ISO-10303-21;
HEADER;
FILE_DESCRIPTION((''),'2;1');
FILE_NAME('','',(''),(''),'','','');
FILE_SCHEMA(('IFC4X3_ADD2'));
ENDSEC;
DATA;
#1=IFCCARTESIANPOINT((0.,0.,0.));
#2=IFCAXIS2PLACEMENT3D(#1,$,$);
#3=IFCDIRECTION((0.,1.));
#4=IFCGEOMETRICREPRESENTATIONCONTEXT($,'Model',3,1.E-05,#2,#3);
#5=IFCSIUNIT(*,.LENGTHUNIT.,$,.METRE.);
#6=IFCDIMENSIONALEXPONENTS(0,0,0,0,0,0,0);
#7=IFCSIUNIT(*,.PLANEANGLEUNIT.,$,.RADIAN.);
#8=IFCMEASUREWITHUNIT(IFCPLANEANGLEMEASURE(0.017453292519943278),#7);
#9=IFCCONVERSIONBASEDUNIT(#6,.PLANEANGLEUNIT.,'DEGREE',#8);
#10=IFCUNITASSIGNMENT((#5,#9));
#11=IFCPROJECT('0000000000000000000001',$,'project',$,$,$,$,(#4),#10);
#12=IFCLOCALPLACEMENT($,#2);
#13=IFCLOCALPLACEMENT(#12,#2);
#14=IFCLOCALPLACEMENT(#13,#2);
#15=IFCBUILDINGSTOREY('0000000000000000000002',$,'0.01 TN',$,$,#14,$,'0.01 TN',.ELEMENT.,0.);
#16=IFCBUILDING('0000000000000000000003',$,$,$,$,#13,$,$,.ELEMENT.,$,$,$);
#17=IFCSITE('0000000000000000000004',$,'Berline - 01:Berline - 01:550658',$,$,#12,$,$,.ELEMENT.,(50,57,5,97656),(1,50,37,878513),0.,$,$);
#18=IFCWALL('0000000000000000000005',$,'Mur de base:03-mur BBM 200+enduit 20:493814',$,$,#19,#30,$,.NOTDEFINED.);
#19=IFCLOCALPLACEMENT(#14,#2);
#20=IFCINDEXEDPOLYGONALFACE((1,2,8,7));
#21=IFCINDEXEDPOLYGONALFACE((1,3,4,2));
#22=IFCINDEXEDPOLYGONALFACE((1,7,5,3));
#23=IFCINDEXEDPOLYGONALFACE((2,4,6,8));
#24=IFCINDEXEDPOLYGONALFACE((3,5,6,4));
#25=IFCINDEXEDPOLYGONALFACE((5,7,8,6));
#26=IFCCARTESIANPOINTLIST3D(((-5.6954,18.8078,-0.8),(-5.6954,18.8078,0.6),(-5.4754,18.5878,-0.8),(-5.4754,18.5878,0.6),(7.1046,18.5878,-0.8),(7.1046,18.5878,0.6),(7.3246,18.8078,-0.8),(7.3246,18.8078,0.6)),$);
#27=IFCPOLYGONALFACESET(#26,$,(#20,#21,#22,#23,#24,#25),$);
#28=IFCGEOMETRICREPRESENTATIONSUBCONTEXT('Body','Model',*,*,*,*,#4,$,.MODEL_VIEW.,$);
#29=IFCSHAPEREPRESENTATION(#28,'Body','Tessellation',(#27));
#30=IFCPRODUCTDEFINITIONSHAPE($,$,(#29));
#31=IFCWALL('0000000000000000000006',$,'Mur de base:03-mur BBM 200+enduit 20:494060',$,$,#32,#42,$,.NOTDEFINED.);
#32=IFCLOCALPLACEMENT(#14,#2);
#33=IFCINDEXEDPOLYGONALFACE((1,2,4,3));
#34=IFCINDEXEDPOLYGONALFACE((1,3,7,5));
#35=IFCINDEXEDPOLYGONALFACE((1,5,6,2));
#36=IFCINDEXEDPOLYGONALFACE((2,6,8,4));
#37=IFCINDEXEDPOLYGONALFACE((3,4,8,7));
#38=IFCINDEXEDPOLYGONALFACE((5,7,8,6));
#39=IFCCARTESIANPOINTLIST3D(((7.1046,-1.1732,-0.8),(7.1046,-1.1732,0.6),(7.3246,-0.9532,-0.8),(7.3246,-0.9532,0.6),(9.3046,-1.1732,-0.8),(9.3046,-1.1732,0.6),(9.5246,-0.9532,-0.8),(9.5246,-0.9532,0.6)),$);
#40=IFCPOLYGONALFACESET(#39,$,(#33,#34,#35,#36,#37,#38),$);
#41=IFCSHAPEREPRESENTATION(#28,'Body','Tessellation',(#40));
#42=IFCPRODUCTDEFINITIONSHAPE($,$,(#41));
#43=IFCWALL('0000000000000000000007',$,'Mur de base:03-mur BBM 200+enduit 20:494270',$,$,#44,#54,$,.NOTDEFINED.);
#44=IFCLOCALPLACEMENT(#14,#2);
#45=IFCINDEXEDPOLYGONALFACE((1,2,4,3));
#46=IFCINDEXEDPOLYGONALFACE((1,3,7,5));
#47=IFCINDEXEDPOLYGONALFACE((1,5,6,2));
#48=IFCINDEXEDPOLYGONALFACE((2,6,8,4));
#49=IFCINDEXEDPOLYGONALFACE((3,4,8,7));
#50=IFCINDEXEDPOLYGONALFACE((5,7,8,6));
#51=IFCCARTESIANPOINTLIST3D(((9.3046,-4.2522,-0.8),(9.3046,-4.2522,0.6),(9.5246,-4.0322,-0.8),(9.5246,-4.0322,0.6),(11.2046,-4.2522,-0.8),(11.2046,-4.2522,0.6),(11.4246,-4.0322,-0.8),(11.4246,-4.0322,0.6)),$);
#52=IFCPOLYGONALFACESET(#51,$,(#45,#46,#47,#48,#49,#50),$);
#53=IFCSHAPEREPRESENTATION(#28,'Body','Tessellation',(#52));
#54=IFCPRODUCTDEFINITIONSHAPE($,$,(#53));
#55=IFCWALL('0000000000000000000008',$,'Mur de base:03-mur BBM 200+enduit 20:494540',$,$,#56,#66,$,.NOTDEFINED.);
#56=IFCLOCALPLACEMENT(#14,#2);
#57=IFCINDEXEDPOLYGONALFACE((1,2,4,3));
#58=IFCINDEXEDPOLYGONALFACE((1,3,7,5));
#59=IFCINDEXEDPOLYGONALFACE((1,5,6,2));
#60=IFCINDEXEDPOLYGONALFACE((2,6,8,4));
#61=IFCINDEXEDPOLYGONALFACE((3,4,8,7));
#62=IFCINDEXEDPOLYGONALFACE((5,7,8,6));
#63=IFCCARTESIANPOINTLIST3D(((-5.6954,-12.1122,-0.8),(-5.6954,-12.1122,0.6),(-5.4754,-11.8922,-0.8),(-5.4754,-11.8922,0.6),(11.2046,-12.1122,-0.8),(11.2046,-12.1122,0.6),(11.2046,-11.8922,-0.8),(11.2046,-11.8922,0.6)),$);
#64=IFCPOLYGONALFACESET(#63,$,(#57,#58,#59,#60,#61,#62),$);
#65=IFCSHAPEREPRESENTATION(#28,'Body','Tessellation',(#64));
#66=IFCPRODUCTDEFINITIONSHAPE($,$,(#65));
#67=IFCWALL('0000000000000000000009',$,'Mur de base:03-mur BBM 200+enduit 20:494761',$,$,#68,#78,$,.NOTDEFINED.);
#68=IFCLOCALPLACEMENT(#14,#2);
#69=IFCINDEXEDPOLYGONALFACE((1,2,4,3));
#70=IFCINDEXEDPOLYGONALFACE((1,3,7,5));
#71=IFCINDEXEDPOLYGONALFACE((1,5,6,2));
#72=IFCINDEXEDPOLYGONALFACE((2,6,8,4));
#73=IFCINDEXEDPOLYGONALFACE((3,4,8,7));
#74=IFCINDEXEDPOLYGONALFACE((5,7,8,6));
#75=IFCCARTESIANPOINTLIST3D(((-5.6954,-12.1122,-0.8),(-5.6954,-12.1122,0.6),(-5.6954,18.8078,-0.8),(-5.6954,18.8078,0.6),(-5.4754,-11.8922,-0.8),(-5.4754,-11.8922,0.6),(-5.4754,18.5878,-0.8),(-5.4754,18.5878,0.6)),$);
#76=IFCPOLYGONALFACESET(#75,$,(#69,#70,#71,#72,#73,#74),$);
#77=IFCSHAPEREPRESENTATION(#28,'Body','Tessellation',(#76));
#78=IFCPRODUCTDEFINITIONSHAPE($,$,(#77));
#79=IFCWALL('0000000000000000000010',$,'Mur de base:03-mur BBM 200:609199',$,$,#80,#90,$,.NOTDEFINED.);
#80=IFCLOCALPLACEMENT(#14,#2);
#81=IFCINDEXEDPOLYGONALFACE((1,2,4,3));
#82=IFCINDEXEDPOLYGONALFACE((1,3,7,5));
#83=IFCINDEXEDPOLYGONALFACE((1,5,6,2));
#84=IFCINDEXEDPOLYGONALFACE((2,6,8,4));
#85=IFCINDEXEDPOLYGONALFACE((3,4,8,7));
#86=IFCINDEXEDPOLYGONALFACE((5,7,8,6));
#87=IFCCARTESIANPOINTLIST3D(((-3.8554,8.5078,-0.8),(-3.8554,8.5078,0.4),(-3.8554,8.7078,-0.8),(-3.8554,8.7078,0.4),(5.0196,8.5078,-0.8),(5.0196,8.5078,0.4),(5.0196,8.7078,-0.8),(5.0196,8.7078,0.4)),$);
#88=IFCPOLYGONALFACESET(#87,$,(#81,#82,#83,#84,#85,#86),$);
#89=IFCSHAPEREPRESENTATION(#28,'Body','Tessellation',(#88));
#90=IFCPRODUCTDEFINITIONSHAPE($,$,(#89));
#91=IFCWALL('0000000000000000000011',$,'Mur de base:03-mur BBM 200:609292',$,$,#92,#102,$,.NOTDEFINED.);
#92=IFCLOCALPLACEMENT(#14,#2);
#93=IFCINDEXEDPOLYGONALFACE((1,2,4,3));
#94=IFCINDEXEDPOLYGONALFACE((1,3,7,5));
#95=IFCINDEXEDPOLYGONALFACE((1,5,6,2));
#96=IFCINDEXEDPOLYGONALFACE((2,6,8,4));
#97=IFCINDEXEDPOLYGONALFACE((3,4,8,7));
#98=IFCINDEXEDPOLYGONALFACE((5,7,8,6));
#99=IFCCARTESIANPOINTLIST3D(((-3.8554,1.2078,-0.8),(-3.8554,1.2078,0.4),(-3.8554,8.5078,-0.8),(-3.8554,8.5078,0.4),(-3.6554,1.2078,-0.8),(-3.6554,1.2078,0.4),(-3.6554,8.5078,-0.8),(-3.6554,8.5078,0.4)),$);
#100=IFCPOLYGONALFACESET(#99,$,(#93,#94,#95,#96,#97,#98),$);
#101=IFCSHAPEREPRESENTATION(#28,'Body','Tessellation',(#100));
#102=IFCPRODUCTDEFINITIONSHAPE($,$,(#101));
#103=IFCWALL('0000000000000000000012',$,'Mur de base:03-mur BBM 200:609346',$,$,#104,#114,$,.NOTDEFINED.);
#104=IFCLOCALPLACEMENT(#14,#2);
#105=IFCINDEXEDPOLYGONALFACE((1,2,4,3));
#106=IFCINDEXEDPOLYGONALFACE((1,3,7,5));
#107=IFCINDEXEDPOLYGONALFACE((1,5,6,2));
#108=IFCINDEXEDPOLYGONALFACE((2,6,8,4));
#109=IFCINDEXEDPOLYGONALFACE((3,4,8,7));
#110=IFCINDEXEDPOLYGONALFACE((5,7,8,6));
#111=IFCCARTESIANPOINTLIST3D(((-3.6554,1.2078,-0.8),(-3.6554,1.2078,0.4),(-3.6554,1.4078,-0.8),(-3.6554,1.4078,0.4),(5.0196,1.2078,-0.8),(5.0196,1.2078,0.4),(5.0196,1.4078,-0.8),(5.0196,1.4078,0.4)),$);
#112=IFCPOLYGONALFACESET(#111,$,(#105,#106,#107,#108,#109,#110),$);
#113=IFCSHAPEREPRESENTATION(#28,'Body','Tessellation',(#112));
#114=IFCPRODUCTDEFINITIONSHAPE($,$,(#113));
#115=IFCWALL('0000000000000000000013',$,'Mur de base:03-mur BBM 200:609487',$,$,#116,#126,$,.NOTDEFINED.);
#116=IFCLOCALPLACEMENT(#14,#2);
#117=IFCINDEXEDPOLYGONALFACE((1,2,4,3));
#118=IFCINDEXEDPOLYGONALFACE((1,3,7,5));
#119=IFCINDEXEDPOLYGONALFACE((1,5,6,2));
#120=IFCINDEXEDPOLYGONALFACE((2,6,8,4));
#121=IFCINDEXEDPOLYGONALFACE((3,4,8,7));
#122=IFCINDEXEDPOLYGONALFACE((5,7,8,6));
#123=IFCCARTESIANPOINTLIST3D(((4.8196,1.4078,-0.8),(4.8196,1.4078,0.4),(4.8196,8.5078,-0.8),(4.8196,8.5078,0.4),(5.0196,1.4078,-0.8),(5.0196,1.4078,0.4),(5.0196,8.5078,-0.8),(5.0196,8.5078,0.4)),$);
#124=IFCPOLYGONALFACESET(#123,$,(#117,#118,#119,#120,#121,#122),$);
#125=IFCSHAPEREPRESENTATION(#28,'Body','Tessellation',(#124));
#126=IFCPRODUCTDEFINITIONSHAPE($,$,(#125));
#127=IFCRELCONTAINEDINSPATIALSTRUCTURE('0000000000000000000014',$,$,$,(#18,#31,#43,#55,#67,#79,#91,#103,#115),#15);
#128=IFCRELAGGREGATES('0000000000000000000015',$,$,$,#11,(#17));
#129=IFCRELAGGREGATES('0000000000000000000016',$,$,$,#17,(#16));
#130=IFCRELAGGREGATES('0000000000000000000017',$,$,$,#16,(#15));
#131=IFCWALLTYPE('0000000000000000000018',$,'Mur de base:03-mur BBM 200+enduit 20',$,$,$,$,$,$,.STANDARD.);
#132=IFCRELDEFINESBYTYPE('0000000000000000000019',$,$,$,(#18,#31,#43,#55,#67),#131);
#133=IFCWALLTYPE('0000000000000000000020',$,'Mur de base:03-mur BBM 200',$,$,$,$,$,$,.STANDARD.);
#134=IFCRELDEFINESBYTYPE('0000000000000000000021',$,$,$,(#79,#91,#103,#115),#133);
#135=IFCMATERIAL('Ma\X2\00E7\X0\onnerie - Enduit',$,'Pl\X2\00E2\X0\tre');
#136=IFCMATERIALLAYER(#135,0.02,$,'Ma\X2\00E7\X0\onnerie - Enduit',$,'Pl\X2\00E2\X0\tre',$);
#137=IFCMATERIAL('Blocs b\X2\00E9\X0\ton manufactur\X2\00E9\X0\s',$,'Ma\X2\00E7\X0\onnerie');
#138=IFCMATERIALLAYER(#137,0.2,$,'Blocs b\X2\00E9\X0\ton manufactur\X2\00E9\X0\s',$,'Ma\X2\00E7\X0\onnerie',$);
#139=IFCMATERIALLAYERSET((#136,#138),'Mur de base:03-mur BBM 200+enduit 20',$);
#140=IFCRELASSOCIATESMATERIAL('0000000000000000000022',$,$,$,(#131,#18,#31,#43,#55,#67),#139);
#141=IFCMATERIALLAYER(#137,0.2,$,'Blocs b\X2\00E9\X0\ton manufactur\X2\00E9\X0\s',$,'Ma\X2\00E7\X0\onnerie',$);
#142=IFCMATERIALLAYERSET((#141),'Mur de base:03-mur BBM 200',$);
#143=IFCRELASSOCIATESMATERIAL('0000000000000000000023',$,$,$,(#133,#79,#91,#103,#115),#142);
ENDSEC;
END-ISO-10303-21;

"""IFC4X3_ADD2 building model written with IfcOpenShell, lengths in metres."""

from ifc_helpers import new_model, entity, si_unit, converted_unit, direction, frame, frame_2d, origin, place, context, subcontext, project, spatial, polyline, rectangle, outline, extrude, material, layer, layer_set, type_object, element, save


model = new_model("IFC4X3_ADD2")

# Units and contexts
model_context = context("Model", 3, precision=1e-05, world=origin(), true_north=direction((0.0, 1.0)))
body_context = subcontext(model_context, "Body", "Model", "MODEL_VIEW")
ifc_project = project(units=[si_unit("LENGTHUNIT", "METRE"), converted_unit("PLANEANGLEUNIT", "DEGREE", entity("IfcPlaneAngleMeasure", 0.017453292519943278), si_unit("PLANEANGLEUNIT", "RADIAN"), dimensions=[0, 0, 0, 0, 0, 0, 0])], contexts=[model_context])

# Site, building, storey
site_placement = place(None, origin())
site = spatial("IfcSite", under=ifc_project, at=site_placement, Name="Berline - 01:Berline - 01:550658", CompositionType="ELEMENT", RefLatitude=(50, 57, 5, 97656), RefLongitude=(1, 50, 37, 878513), RefElevation=0.0)
building_placement = place(site_placement, origin())
building = spatial("IfcBuilding", under=site, at=building_placement, CompositionType="ELEMENT")
storey_placement = place(building_placement, origin())
storey = spatial("IfcBuildingStorey", under=building, at=storey_placement, Name="0.01 TN", LongName="0.01 TN", CompositionType="ELEMENT", Elevation=0.0)

# Walls
ifc_material_1 = material(Name="Maçonnerie - Enduit", Category="Plâtre")
ifc_layer_1 = layer(ifc_material_1, 0.02, Name="Maçonnerie - Enduit", Category="Plâtre")
ifc_material_2 = material(Name="Blocs béton manufacturés", Category="Maçonnerie")
ifc_layer_2 = layer(ifc_material_2, 0.2, Name="Blocs béton manufacturés", Category="Maçonnerie")
ifc_layer_set_1 = layer_set([ifc_layer_1, ifc_layer_2], Name="Mur de base:03-mur BBM 200+enduit 20")
wall_type_1 = type_object("IfcWallType", Name="Mur de base:03-mur BBM 200+enduit 20", PredefinedType="STANDARD", material=ifc_layer_set_1)
wall_1_placement = place(storey_placement, frame((-5.6954, 18.6978, -0.8)))
element("IfcWall", 1, at=wall_1_placement, inside=storey, type_object=wall_type_1, material=ifc_layer_set_1, Name="Mur de base:03-mur BBM 200+enduit 20:493814", PredefinedType="NOTDEFINED", context=body_context, shape_type="SweptSolid", body=[
    extrude(outline(polyline([(12.8, -0.11), (13.02, 0.11), (0.0, 0.11), (0.22, -0.11), (12.8, -0.11)])), origin(), (0.0, 0.0, 1.0), 1.4),
])
wall_2_placement = place(storey_placement, frame((7.1046, -1.0632, -0.8)))
element("IfcWall", 2, at=wall_2_placement, inside=storey, type_object=wall_type_1, material=ifc_layer_set_1, Name="Mur de base:03-mur BBM 200+enduit 20:494060", PredefinedType="NOTDEFINED", context=body_context, shape_type="SweptSolid", body=[
    extrude(outline(polyline([(2.2, -0.11), (2.42, 0.11), (0.22, 0.11), (0.0, -0.11), (2.2, -0.11)])), origin(), (0.0, 0.0, 1.0), 1.4),
])
wall_3_placement = place(storey_placement, frame((9.3046, -4.1422, -0.8)))
element("IfcWall", 3, at=wall_3_placement, inside=storey, type_object=wall_type_1, material=ifc_layer_set_1, Name="Mur de base:03-mur BBM 200+enduit 20:494270", PredefinedType="NOTDEFINED", context=body_context, shape_type="SweptSolid", body=[
    extrude(outline(polyline([(1.9, -0.11), (2.12, 0.11), (0.22, 0.11), (0.0, -0.11), (1.9, -0.11)])), origin(), (0.0, 0.0, 1.0), 1.4),
])
wall_4_placement = place(storey_placement, frame((11.2046, -12.0022, -0.8), z_axis=(0.0, 0.0, 1.0), x_axis=(-1.0, 0.0, 0.0)))
element("IfcWall", 4, at=wall_4_placement, inside=storey, type_object=wall_type_1, material=ifc_layer_set_1, Name="Mur de base:03-mur BBM 200+enduit 20:494540", PredefinedType="NOTDEFINED", context=body_context, shape_type="SweptSolid", body=[
    extrude(outline(polyline([(16.68, -0.11), (16.9, 0.11), (0.0, 0.11), (0.0, -0.11), (16.68, -0.11)])), origin(), (0.0, 0.0, 1.0), 1.4),
])
wall_5_placement = place(storey_placement, frame((-5.5854, -12.1122, -0.8), z_axis=(0.0, 0.0, 1.0), x_axis=(0.0, 1.0, 0.0)))
element("IfcWall", 5, at=wall_5_placement, inside=storey, type_object=wall_type_1, material=ifc_layer_set_1, Name="Mur de base:03-mur BBM 200+enduit 20:494761", PredefinedType="NOTDEFINED", context=body_context, shape_type="SweptSolid", body=[
    extrude(outline(polyline([(30.7, -0.11), (30.92, 0.11), (0.0, 0.11), (0.22, -0.11), (30.7, -0.11)])), origin(), (0.0, 0.0, 1.0), 1.4),
])
ifc_layer_3 = layer(ifc_material_2, 0.2, Name="Blocs béton manufacturés", Category="Maçonnerie")
ifc_layer_set_2 = layer_set([ifc_layer_3], Name="Mur de base:03-mur BBM 200")
wall_type_2 = type_object("IfcWallType", Name="Mur de base:03-mur BBM 200", PredefinedType="STANDARD", material=ifc_layer_set_2)
wall_6_placement = place(storey_placement, frame((5.0196, 8.6078, -0.8), z_axis=(0.0, 0.0, 1.0), x_axis=(-1.0, 0.0, 0.0)))
element("IfcWall", 6, at=wall_6_placement, inside=storey, type_object=wall_type_2, material=ifc_layer_set_2, Name="Mur de base:03-mur BBM 200:609199", PredefinedType="NOTDEFINED", context=body_context, shape_type="SweptSolid", body=[
    extrude(rectangle(XDim=8.875, YDim=0.2, at=frame_2d((4.4375, 0.0), x_axis=(-1.0, 0.0))), origin(), (0.0, 0.0, 1.0), 1.2),
])
wall_7_placement = place(storey_placement, frame((-3.7554, 8.5078, -0.8), z_axis=(0.0, 0.0, 1.0), x_axis=(0.0, -1.0, 0.0)))
element("IfcWall", 7, at=wall_7_placement, inside=storey, type_object=wall_type_2, material=ifc_layer_set_2, Name="Mur de base:03-mur BBM 200:609292", PredefinedType="NOTDEFINED", context=body_context, shape_type="SweptSolid", body=[
    extrude(rectangle(XDim=7.3, YDim=0.2, at=frame_2d((3.65, 0.0), x_axis=(-1.0, 0.0))), origin(), (0.0, 0.0, 1.0), 1.2),
])
wall_8_placement = place(storey_placement, frame((-3.6554, 1.3078, -0.8)))
element("IfcWall", 8, at=wall_8_placement, inside=storey, type_object=wall_type_2, material=ifc_layer_set_2, Name="Mur de base:03-mur BBM 200:609346", PredefinedType="NOTDEFINED", context=body_context, shape_type="SweptSolid", body=[
    extrude(rectangle(XDim=8.675, YDim=0.2, at=frame_2d((4.3375, 0.0), x_axis=(-1.0, 0.0))), origin(), (0.0, 0.0, 1.0), 1.2),
])
wall_9_placement = place(storey_placement, frame((4.9196, 8.5078, -0.8), z_axis=(0.0, 0.0, 1.0), x_axis=(0.0, -1.0, 0.0)))
element("IfcWall", 9, at=wall_9_placement, inside=storey, type_object=wall_type_2, material=ifc_layer_set_2, Name="Mur de base:03-mur BBM 200:609487", PredefinedType="NOTDEFINED", context=body_context, shape_type="SweptSolid", body=[
    extrude(rectangle(XDim=7.1, YDim=0.2, at=frame_2d((3.55, 0.0), x_axis=(-1.0, 0.0))), origin(), (0.0, 0.0, 1.0), 1.2),
])

save(model, "model.ifc")
